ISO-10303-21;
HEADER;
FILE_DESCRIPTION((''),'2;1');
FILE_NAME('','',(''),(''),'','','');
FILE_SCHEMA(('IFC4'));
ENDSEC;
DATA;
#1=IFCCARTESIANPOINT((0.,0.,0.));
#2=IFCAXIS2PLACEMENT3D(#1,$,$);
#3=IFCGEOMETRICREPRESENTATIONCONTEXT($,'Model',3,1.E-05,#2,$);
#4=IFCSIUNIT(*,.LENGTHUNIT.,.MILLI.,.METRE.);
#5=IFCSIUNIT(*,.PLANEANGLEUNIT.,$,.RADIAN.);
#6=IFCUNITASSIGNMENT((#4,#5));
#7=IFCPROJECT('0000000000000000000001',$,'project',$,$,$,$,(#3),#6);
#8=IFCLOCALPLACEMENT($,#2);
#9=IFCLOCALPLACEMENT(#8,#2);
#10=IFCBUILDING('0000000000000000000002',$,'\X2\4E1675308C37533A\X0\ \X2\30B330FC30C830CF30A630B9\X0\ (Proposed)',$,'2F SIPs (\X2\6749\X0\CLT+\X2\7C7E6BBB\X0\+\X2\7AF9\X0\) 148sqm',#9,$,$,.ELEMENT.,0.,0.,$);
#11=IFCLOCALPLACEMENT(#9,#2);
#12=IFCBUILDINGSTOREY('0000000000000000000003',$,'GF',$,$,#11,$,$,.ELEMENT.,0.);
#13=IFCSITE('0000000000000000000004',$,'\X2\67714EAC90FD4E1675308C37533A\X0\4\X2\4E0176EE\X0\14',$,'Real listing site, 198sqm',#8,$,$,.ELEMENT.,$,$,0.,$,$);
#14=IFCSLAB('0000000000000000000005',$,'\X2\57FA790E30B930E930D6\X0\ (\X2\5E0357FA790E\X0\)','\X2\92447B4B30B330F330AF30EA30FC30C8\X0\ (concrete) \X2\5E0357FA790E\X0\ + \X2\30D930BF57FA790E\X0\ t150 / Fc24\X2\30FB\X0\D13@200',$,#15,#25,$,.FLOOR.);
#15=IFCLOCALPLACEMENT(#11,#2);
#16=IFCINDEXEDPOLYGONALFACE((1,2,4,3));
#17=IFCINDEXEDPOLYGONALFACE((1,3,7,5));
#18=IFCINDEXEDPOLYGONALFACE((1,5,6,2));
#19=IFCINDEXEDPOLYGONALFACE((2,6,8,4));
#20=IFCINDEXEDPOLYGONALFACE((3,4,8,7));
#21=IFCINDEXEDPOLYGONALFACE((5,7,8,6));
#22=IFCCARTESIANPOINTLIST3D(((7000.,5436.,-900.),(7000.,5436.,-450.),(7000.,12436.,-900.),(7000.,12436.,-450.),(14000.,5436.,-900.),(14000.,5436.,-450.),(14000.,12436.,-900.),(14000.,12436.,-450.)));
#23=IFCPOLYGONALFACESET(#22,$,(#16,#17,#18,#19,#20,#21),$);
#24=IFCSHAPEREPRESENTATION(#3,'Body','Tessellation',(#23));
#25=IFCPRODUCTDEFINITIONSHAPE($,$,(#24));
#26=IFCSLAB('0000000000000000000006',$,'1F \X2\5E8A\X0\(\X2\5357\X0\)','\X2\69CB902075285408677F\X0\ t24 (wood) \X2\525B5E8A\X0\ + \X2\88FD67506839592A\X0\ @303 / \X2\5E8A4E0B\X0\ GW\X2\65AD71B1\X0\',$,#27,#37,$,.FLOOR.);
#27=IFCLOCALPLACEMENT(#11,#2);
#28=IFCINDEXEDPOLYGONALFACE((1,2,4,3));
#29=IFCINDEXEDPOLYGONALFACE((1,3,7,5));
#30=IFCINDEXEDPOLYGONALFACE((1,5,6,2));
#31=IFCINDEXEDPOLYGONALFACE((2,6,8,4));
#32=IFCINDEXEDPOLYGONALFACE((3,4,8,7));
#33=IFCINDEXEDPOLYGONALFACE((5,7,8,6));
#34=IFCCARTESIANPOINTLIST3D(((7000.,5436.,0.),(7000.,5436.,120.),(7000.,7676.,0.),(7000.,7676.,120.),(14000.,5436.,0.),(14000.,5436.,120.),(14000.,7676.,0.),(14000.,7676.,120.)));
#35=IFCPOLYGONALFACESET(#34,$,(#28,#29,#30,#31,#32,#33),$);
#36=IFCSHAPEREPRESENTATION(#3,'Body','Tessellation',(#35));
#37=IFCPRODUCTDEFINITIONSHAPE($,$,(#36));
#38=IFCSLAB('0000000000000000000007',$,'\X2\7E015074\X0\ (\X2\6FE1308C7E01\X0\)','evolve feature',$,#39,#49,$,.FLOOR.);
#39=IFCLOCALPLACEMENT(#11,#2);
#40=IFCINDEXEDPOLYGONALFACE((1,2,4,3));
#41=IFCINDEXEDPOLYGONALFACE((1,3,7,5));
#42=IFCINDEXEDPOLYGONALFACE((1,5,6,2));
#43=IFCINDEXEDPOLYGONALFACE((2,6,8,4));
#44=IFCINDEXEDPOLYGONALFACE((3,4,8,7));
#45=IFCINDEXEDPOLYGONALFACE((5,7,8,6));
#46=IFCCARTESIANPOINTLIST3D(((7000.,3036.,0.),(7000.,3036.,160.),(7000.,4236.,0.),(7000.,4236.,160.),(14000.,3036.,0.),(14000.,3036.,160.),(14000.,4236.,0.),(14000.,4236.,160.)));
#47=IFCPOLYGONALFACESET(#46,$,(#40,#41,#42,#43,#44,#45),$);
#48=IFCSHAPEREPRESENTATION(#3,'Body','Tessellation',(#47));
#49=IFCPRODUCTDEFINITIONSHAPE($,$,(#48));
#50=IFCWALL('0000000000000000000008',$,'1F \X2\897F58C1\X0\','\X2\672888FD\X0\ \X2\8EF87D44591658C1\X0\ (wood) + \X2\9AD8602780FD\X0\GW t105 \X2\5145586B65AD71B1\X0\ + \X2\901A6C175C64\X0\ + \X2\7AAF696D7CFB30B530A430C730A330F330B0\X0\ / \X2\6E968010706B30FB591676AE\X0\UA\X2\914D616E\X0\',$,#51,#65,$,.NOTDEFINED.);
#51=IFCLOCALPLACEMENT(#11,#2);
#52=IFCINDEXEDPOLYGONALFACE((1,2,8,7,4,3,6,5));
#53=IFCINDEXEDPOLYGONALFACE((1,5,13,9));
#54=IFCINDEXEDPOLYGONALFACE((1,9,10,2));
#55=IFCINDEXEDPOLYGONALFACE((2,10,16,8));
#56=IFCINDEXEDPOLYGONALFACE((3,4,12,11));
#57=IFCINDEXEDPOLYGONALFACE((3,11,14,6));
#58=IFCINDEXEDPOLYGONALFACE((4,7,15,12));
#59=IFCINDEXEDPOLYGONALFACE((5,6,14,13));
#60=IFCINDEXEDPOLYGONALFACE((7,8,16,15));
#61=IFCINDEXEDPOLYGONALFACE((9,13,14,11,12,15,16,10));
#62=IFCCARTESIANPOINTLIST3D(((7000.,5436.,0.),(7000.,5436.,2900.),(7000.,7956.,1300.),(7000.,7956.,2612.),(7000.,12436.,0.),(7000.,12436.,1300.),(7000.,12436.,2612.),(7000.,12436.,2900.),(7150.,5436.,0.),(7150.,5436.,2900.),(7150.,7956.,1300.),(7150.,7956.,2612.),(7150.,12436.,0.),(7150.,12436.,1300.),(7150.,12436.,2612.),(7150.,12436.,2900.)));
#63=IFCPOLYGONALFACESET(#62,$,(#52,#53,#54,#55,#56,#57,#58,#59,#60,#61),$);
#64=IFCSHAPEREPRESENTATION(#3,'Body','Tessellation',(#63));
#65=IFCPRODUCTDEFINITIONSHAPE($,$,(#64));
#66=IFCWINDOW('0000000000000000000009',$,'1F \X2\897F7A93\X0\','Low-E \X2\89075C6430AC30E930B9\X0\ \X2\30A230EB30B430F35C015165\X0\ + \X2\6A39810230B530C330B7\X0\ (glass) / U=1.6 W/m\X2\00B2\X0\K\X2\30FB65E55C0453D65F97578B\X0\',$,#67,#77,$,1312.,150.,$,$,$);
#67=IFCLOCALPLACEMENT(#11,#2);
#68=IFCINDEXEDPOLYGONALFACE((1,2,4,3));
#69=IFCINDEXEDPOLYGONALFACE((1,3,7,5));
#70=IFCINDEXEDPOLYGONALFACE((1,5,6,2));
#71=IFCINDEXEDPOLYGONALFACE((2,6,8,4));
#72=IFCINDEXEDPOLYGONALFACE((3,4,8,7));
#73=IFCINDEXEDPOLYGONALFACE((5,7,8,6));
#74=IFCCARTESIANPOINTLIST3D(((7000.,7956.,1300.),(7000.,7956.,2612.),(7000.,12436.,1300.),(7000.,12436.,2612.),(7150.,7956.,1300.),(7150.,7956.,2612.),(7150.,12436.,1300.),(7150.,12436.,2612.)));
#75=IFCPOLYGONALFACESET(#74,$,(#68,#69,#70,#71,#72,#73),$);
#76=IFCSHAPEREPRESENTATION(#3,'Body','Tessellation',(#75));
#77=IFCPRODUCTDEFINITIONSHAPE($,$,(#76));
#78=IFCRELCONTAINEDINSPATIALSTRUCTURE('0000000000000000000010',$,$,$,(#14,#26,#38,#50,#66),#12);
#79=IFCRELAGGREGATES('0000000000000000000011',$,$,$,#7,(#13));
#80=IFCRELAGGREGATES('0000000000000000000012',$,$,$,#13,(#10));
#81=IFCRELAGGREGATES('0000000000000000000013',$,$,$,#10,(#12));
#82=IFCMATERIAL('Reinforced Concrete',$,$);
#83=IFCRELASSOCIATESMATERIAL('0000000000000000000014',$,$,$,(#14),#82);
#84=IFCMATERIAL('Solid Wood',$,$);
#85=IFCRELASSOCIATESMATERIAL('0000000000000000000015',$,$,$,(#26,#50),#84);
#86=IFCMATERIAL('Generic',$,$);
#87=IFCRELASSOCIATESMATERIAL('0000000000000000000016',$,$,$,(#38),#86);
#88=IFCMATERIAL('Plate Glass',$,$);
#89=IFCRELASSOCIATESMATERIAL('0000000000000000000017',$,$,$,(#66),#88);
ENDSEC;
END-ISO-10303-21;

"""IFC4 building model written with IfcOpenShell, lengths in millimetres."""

from ifc_helpers import new_model, si_unit, frame, frame_2d, origin, place, context, project, spatial, rectangle, extrude, material, element, fill, save


model = new_model("IFC4")

# Units and contexts
model_context = context("Model", 3, precision=1e-05, world=origin())
ifc_project = project(units=[si_unit("LENGTHUNIT", "METRE", prefix="MILLI"), si_unit("PLANEANGLEUNIT", "RADIAN")], contexts=[model_context])

# Site, building, storey
site_placement = place(None, origin())
site = spatial("IfcSite", under=ifc_project, at=site_placement, Name="東京都世田谷区4丁目14", ObjectType="Real listing site, 198sqm", CompositionType="ELEMENT", RefElevation=0.0)
building_placement = place(site_placement, origin())
building = spatial("IfcBuilding", under=site, at=building_placement, Name="世田谷区 コートハウス (Proposed)", ObjectType="2F SIPs (杉CLT+籾殻+竹) 148sqm", CompositionType="ELEMENT", ElevationOfRefHeight=0.0, ElevationOfTerrain=0.0)
storey_placement = place(building_placement, origin())
storey = spatial("IfcBuildingStorey", under=building, at=storey_placement, Name="GF", CompositionType="ELEMENT", Elevation=0.0)

# Slabs
ifc_material_1 = material(Name="Reinforced Concrete")
slab_1_placement = place(storey_placement, frame((3500.0, 2718.0, -450.0)))
element("IfcSlab", 1, at=slab_1_placement, inside=storey, material=ifc_material_1, Name="基礎スラブ (布基礎)", Description="鉄筋コンクリート (concrete) 布基礎 + ベタ基礎 t150 / Fc24・D13@200", PredefinedType="FLOOR", context=model_context, shape_type="SweptSolid", body=[
    extrude(rectangle(XDim=7000.0, YDim=7000.0, at=frame_2d((3500.0, 3500.0))), frame((3500.0, 2718.0, -450.0)), (0.0, 0.0, 1.0), 450.0),
])
ifc_material_2 = material(Name="Solid Wood")
slab_2_placement = place(storey_placement, frame((3500.0, 2718.0, 0.0)))
element("IfcSlab", 2, at=slab_2_placement, inside=storey, material=ifc_material_2, Name="1F 床(南)", Description="構造用合板 t24 (wood) 剛床 + 製材根太 @303 / 床下 GW断熱", PredefinedType="FLOOR", context=model_context, shape_type="SweptSolid", body=[
    extrude(rectangle(XDim=7000.0, YDim=2240.0, at=frame_2d((3500.0, 1120.0))), frame((3500.0, 2718.0, 0.0)), (0.0, 0.0, 1.0), 120.0),
])
ifc_material_3 = material(Name="Generic")
slab_3_placement = place(storey_placement, frame((3500.0, 1518.0, 0.0)))
element("IfcSlab", 3, at=slab_3_placement, inside=storey, material=ifc_material_3, Name="縁側 (濡れ縁)", Description="evolve feature", PredefinedType="FLOOR", context=model_context, shape_type="SweptSolid", body=[
    extrude(rectangle(XDim=7000.0, YDim=1200.0, at=frame_2d((3500.0, 600.0))), frame((3500.0, 1518.0, 0.0)), (0.0, 0.0, 1.0), 160.0),
])

# Shared definitions
ifc_material_4 = material(Name="Plate Glass")

# Wall, opening, window
wall_1_placement = place(storey_placement, frame((3500.0, 2718.0, 0.0)))
wall_1 = element("IfcWall", 4, at=wall_1_placement, inside=storey, material=ifc_material_2, Name="1F 西壁", Description="木製 軸組外壁 (wood) + 高性能GW t105 充填断熱 + 通気層 + 窯業系サイディング / 準耐火・外皮UA配慮", PredefinedType="NOTDEFINED", context=model_context, shape_type="SweptSolid", body=[
    extrude(rectangle(XDim=150.0, YDim=7000.0, at=frame_2d((75.0, 3500.0))), frame((3500.0, 2718.0, 0.0)), (0.0, 0.0, 1.0), 2900.0),
])
opening_1_placement = place(storey_placement, frame((3500.0, 3978.0, 650.0)))
opening_1 = element("IfcOpeningElement", 5, at=opening_1_placement, cuts=wall_1, PredefinedType="NOTDEFINED", context=model_context, shape_type="SweptSolid", body=[
    extrude(rectangle(XDim=150.0, YDim=4480.0, at=frame_2d((75.0, 2240.0))), frame((3500.0, 3978.0, 650.0)), (0.0, 0.0, 1.0), 1312.0),
])
window_1_placement = place(storey_placement, frame((3500.0, 3978.0, 650.0)))
window_1 = element("IfcWindow", 6, at=window_1_placement, inside=storey, material=ifc_material_4, Name="1F 西窓", Description="Low-E 複層ガラス アルゴン封入 + 樹脂サッシ (glass) / U=1.6 W/m²K・日射取得型", OverallHeight=1312.0, OverallWidth=150.0, context=model_context, shape_type="SweptSolid", body=[
    extrude(rectangle(XDim=150.0, YDim=4480.0, at=frame_2d((75.0, 2240.0))), frame((3500.0, 3978.0, 650.0)), (0.0, 0.0, 1.0), 1312.0),
])
fill(opening_1, window_1)

save(model, "model.ifc")
